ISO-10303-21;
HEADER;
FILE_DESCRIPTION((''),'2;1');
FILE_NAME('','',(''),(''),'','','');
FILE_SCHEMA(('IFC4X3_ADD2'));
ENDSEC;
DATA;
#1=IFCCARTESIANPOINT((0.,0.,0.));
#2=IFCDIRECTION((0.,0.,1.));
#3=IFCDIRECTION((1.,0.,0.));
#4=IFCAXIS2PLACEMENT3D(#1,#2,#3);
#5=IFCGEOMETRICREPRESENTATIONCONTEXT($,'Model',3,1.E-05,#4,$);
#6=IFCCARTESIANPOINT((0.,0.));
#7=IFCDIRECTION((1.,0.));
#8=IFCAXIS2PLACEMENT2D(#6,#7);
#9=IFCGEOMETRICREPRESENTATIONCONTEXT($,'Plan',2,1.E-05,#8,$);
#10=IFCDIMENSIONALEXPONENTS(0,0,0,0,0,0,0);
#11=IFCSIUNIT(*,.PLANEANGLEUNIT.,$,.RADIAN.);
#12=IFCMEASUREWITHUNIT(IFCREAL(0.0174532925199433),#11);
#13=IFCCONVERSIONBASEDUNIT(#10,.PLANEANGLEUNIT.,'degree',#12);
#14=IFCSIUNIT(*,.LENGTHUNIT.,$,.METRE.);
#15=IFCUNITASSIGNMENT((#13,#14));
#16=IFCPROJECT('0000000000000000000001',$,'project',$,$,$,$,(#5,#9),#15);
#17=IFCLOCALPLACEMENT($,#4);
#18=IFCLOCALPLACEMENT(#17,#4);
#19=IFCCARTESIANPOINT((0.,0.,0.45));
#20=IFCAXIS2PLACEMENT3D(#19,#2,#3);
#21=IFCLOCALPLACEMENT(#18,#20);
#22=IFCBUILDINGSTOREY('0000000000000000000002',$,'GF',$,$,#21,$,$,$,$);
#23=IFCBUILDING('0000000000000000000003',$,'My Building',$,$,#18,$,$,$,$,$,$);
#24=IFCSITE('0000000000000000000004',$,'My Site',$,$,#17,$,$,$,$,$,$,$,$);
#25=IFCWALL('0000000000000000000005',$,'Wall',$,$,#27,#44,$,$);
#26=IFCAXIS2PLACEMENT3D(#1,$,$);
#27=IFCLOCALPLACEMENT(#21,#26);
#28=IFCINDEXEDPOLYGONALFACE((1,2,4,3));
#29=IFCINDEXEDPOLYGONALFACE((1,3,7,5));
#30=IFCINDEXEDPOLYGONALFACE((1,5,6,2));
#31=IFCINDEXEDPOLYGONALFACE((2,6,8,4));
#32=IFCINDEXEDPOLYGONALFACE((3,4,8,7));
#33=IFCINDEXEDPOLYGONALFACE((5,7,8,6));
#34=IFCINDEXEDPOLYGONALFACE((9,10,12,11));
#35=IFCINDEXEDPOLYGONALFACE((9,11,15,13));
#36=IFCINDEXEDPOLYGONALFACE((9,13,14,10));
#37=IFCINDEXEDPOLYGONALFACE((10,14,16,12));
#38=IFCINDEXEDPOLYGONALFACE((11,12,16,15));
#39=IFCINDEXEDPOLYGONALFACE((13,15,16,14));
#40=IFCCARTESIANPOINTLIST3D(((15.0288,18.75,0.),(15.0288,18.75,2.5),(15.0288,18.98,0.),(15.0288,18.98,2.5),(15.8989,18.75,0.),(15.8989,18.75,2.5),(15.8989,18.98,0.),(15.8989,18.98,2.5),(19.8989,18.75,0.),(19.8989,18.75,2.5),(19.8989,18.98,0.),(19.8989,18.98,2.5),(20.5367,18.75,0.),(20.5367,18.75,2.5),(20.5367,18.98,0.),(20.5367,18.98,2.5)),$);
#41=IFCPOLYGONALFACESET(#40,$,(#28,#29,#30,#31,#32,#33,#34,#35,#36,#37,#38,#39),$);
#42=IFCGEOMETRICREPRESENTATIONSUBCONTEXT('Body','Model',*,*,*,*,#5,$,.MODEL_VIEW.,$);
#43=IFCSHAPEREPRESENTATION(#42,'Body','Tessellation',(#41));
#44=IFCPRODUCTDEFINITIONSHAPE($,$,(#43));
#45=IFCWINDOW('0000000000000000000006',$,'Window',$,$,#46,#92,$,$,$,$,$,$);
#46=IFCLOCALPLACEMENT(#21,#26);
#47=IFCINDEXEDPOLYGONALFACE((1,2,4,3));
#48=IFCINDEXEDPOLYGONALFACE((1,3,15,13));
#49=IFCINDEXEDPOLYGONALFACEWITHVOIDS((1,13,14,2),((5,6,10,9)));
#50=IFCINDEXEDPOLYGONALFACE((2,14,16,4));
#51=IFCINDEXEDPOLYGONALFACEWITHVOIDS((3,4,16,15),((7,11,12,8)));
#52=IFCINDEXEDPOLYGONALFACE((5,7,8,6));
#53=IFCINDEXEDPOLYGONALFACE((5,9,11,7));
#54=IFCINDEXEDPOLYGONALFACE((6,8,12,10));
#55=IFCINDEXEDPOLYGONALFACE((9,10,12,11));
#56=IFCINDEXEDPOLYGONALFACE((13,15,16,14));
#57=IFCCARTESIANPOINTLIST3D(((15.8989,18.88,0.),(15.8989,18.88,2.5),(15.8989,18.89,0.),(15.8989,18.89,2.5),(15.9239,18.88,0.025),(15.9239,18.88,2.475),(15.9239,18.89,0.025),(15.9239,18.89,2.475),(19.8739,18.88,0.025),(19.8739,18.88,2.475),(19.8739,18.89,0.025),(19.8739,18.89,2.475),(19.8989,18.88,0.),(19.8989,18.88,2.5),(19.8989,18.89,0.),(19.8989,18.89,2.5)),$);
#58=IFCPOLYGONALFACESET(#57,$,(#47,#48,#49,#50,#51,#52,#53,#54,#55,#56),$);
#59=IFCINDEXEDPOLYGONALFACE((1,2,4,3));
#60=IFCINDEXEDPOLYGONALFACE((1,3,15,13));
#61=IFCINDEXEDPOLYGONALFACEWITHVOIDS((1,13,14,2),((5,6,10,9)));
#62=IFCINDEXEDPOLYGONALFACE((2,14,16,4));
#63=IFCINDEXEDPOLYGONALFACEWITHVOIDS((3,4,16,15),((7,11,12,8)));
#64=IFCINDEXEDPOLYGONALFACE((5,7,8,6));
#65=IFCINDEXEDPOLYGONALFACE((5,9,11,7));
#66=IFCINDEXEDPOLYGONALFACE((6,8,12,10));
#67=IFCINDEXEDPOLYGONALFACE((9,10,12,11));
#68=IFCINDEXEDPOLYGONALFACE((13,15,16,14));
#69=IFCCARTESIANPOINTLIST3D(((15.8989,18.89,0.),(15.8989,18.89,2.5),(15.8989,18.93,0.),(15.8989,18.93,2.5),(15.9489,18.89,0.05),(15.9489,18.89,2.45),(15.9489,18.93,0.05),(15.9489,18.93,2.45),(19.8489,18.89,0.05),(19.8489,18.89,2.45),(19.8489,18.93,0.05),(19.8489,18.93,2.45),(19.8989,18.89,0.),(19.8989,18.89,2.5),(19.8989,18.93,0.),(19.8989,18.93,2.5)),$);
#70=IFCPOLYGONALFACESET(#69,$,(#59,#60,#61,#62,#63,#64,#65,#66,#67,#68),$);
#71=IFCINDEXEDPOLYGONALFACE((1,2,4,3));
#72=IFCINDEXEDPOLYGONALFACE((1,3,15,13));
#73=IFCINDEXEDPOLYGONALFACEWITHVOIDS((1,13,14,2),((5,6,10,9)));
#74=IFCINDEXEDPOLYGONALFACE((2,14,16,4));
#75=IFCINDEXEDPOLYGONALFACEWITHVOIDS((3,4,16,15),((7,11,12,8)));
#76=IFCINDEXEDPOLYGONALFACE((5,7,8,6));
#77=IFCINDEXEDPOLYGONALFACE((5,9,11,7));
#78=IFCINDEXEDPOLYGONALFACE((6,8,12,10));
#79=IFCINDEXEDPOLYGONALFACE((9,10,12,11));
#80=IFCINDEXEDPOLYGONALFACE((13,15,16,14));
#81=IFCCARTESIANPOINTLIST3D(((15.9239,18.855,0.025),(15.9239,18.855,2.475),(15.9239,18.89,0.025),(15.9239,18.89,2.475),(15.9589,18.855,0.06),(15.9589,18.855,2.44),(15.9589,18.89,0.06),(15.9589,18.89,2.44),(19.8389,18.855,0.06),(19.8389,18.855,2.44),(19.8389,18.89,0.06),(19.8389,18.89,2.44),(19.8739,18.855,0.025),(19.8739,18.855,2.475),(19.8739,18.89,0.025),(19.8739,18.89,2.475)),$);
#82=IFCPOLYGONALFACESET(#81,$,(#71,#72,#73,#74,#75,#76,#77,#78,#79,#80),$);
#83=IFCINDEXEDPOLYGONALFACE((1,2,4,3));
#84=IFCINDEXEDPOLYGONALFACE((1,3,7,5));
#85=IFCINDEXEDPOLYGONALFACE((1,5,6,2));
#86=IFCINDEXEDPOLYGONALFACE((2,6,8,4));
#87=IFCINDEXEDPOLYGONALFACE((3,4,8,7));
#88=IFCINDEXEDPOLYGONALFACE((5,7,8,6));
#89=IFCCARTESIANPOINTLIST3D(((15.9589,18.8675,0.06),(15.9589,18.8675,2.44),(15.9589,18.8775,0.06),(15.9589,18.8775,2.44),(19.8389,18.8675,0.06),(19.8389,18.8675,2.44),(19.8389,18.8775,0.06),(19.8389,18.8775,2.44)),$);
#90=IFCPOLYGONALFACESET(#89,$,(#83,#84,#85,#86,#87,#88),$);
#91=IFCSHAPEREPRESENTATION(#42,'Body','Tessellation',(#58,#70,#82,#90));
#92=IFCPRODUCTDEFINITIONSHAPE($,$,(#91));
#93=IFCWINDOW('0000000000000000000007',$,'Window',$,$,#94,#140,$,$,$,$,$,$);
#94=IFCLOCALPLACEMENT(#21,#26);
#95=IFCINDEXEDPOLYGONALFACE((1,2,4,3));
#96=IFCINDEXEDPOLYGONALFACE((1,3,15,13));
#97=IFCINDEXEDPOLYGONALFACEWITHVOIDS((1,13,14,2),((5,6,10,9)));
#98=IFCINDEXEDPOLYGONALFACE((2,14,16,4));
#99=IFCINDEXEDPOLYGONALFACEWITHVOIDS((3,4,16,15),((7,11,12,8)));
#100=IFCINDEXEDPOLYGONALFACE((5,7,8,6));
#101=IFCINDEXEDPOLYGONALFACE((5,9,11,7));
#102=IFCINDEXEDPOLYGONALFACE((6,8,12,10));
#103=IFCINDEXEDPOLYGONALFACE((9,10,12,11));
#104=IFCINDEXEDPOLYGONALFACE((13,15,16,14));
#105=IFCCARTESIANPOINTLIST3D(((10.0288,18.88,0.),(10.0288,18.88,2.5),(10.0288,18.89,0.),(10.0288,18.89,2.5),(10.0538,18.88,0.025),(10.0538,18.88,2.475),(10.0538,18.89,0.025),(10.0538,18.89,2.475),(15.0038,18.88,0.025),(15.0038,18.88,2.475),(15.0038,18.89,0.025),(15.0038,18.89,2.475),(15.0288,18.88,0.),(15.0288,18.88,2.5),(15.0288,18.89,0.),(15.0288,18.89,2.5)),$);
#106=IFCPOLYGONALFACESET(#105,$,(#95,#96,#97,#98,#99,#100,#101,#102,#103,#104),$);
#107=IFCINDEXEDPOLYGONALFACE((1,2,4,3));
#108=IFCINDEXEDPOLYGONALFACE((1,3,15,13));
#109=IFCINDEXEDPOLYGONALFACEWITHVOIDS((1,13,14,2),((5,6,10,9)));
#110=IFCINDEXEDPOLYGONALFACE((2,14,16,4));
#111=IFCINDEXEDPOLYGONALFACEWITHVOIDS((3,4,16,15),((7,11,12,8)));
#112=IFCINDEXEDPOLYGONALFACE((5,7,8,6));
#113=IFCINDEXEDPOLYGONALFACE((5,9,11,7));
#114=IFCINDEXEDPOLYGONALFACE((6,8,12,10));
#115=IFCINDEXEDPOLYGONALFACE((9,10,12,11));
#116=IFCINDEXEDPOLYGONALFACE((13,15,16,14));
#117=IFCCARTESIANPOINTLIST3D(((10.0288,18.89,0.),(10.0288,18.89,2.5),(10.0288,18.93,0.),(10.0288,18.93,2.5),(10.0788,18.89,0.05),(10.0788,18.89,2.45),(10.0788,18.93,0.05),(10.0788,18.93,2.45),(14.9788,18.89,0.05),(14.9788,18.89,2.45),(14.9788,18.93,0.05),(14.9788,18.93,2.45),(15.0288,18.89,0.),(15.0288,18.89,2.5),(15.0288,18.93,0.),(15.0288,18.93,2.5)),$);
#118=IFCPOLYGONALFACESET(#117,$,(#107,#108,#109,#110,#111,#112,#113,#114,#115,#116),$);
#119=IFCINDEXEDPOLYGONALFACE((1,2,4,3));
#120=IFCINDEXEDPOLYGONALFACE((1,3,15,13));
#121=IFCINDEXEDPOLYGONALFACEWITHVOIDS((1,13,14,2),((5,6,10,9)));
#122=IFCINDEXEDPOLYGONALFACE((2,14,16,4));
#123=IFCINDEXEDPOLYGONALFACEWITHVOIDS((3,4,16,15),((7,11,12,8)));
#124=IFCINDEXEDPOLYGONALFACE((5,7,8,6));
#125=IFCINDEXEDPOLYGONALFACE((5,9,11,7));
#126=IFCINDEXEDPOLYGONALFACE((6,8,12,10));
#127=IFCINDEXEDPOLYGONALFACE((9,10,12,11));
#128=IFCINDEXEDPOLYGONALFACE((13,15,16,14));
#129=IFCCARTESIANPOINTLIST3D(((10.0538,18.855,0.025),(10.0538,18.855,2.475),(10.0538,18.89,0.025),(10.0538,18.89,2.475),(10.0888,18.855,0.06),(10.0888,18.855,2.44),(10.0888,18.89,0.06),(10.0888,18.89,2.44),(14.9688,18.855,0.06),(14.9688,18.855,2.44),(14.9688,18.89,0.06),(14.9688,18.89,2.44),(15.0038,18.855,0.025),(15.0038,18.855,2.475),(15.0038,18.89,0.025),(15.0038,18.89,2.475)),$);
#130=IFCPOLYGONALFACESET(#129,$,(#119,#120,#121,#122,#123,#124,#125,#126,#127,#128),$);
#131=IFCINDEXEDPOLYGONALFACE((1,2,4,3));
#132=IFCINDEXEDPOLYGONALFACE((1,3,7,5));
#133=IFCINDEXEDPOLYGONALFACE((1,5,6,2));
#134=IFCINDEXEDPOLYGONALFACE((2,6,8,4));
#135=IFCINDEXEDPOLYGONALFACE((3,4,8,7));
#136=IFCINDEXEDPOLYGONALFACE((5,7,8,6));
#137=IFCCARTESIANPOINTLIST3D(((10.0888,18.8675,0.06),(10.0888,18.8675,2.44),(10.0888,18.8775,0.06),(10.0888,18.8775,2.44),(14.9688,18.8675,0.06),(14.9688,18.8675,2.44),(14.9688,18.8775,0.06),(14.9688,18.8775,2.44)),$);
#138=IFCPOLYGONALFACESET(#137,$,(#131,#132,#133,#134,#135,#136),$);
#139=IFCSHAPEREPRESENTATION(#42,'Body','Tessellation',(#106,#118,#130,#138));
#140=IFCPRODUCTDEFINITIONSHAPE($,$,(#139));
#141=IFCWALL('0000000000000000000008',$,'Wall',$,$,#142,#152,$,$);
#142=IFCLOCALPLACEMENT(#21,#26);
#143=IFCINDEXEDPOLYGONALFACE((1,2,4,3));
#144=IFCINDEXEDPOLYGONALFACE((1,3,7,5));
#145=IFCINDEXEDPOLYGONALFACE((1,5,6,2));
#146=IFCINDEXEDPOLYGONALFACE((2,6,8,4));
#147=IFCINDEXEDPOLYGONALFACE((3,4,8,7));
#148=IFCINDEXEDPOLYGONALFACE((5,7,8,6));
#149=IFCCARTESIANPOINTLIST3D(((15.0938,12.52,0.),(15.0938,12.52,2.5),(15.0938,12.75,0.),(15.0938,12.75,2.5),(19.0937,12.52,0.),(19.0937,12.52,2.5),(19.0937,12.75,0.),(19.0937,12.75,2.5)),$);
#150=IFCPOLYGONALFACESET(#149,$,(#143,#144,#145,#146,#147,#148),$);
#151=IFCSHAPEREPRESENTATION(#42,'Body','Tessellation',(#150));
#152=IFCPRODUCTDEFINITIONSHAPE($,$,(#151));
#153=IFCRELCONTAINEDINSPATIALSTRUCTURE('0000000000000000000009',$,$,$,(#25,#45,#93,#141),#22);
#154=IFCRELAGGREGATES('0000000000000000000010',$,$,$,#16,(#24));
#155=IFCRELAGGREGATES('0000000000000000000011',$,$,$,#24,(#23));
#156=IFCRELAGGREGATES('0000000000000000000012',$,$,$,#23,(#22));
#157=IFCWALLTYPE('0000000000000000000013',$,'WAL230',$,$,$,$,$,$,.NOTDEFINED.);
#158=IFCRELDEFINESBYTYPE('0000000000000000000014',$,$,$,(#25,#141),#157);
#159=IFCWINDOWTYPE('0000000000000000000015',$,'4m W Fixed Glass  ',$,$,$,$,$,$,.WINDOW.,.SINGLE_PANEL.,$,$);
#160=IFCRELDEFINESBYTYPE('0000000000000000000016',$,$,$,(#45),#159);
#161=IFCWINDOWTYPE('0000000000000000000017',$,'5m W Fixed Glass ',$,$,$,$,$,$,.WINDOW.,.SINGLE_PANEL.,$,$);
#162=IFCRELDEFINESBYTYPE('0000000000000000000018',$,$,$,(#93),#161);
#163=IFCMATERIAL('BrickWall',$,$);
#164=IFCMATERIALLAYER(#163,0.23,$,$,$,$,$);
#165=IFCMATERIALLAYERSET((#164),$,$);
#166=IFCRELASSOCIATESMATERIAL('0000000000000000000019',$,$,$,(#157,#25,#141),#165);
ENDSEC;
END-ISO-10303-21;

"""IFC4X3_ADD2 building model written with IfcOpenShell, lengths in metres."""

from ifc_helpers import new_model, entity, si_unit, converted_unit, frame, origin_with_axes, origin_2d_with_axis, place, context, subcontext, project, spatial, line, indexed_curve, outline, extrude, shape, source, transform, mapped, material, layer, layer_set, layer_usage, type_object, type_shapes, element, fill, save


model = new_model("IFC4X3_ADD2")

# Units and contexts
model_context = context("Model", 3, precision=1e-05, world=origin_with_axes())
plan_context = context("Plan", 2, precision=1e-05, world=origin_2d_with_axis())
body_context_1 = subcontext(model_context, "Body", "Model", "MODEL_VIEW")
body_context_2 = subcontext(plan_context, "Body", "Plan", "PLAN_VIEW")
ifc_project = project(units=[converted_unit("PLANEANGLEUNIT", "degree", entity("IfcReal", 0.0174532925199433), si_unit("PLANEANGLEUNIT", "RADIAN"), dimensions=[0, 0, 0, 0, 0, 0, 0]), si_unit("LENGTHUNIT", "METRE")], contexts=[model_context, plan_context])

# Site, building, storey
site_placement = place(None, origin_with_axes())
site = spatial("IfcSite", under=ifc_project, at=site_placement, Name="My Site")
building_placement = place(site_placement, origin_with_axes())
building = spatial("IfcBuilding", under=site, at=building_placement, Name="My Building")
storey_placement = place(building_placement, frame((0.0, 0.0, 0.45), z_axis=(0.0, 0.0, 1.0), x_axis=(1.0, 0.0, 0.0)))
storey = spatial("IfcBuildingStorey", under=building, at=storey_placement, Name="GF")

# Wall, openings, windows
ifc_material_1 = material(Name="BrickWall")
ifc_layer_1 = layer(ifc_material_1, 0.23)
ifc_layer_set_1 = layer_set([ifc_layer_1])
ifc_layer_usage_1 = layer_usage(ifc_layer_set_1, "AXIS2", "POSITIVE", 0.0)
wall_type_1 = type_object("IfcWallType", Name="WAL230", PredefinedType="NOTDEFINED", material=ifc_layer_set_1)
wall_1_placement = place(storey_placement, frame((20.5367, 18.98, 0.0), z_axis=(0.0, 0.0, 1.0), x_axis=(-1.0, 0.0, 0.0)))
wall_1 = element("IfcWall", 1, at=wall_1_placement, inside=storey, type_object=wall_type_1, material=ifc_layer_usage_1, Name="Wall", context=body_context_1, shape_type="SweptSolid", body=[
    extrude(outline(indexed_curve([(0.0, 0.0), (0.0, 0.23), (10.5079, 0.23), (10.5079, 0.0), (0.0, 0.0)], self_intersect=False)), origin_with_axes(), (0.0, 0.0, 1.0), 2.5),
])
shared_shape_1 = source(origin_with_axes(), body_context_1, "Body", "SweptSolid", [
    extrude(outline(indexed_curve([(0.0, 0.0), (5.0, 0.0), (5.0, 2.5), (0.0, 2.5)], segments=[line(1, 2, 3, 4, 1)])), frame((0.0, -0.6, 0.0), z_axis=(0.0, -1.0, 0.0), x_axis=(1.0, 0.0, 0.0)), (0.0, 0.0, -1.0), 1.2),
])
opening_1_placement = place(wall_1_placement, frame((5.5079, 0.0, 0.0), z_axis=(0.0, 0.0, 1.0), x_axis=(1.0, 0.0, 0.0)))
opening_1 = element("IfcOpeningElement", 2, at=opening_1_placement, cuts=wall_1, PredefinedType="OPENING", context=body_context_1, shape_type="MappedRepresentation", body=[
    mapped(shared_shape_1, transform((0.0, 0.0, 0.0), x_axis=(1.0, 0.0, 0.0), y_axis=(0.0, 1.0, 0.0), z_axis=(0.0, 0.0, 1.0), scale=1.0)),
])
shared_shape_2 = source(origin_with_axes(), body_context_1, "Body", "SweptSolid", [
    extrude(outline(indexed_curve([(0.0, 0.0), (4.0, 0.0), (4.0, 2.5), (0.0, 2.5)], segments=[line(1, 2, 3, 4, 1)])), frame((0.0, -0.6, 0.0), z_axis=(0.0, -1.0, 0.0), x_axis=(1.0, 0.0, 0.0)), (0.0, 0.0, -1.0), 1.2),
])
opening_2_placement = place(wall_1_placement, frame((0.6379, 0.0, 0.0), z_axis=(0.0, 0.0, 1.0), x_axis=(1.0, 0.0, 0.0)))
opening_2 = element("IfcOpeningElement", 3, at=opening_2_placement, cuts=wall_1, PredefinedType="OPENING", context=body_context_1, shape_type="MappedRepresentation", body=[
    mapped(shared_shape_2, transform((0.0, 0.0, 0.0), x_axis=(1.0, 0.0, 0.0), y_axis=(0.0, 1.0, 0.0), z_axis=(0.0, 0.0, 1.0), scale=1.0)),
])
window_type_1 = type_object("IfcWindowType", Name="4m W Fixed Glass  ", PartitioningType="SINGLE_PANEL", PredefinedType="WINDOW")
shared_shape_3 = source(origin_with_axes(), body_context_1, "Body", "SweptSolid", [
    extrude(outline(indexed_curve([(0.0, 0.0), (4.0, 0.0), (4.0, 2.5), (0.0, 2.5)], segments=[line(1, 2, 3, 4, 1)]), holes=[indexed_curve([(0.025, 0.025), (3.975, 0.025), (3.975, 2.475), (0.025, 2.475)], segments=[line(1, 2, 3, 4, 1)])]), frame((0.0, 0.09, 0.0), z_axis=(0.0, -1.0, 0.0), x_axis=(1.0, 0.0, 0.0)), (0.0, 0.0, -1.0), 0.01),
    extrude(outline(indexed_curve([(0.0, 0.0), (4.0, 0.0), (4.0, 2.5), (0.0, 2.5)], segments=[line(1, 2, 3, 4, 1)]), holes=[indexed_curve([(0.05, 0.05), (3.95, 0.05), (3.95, 2.45), (0.05, 2.45)], segments=[line(1, 2, 3, 4, 1)])]), frame((0.0, 0.05, 0.0), z_axis=(0.0, -1.0, 0.0), x_axis=(1.0, 0.0, 0.0)), (0.0, 0.0, -1.0), 0.04),
    extrude(outline(indexed_curve([(0.0, 0.0), (3.95, 0.0), (3.95, 2.45), (0.0, 2.45)], segments=[line(1, 2, 3, 4, 1)]), holes=[indexed_curve([(0.035, 0.035), (3.915, 0.035), (3.915, 2.415), (0.035, 2.415)], segments=[line(1, 2, 3, 4, 1)])]), frame((0.025, 0.09, 0.025), z_axis=(0.0, -1.0, 0.0), x_axis=(1.0, 0.0, 0.0)), (0.0, 0.0, -1.0), 0.035),
    extrude(outline(indexed_curve([(0.035, 0.035), (3.915, 0.035), (3.915, 2.415), (0.035, 2.415)], segments=[line(1, 2, 3, 4, 1)])), frame((0.025, 0.1025, 0.025), z_axis=(0.0, -1.0, 0.0), x_axis=(1.0, 0.0, 0.0)), (0.0, 0.0, -1.0), 0.01),
])
shared_shape_4 = source(origin_with_axes(), body_context_2, "Body", "Curve2D", [
    entity("IfcIndexedPolyCurve", entity("IfcCartesianPointList2D", [[0.05, 0.05], [3.95, 0.05]])),
    entity("IfcIndexedPolyCurve", entity("IfcCartesianPointList2D", [[0.0, 0.1], [0.025, 0.1], [0.025, 0.09], [0.05, 0.09], [0.05, 0.05], [0.0, 0.05]]), [entity("IfcLineIndex", [1, 2, 3, 4, 5, 6, 1])]),
    entity("IfcIndexedPolyCurve", entity("IfcCartesianPointList2D", [[4.0, 0.1], [3.975, 0.1], [3.975, 0.09], [3.95, 0.09], [3.95, 0.05], [4.0, 0.05]]), [entity("IfcLineIndex", [1, 2, 3, 4, 5, 6, 1])]),
    entity("IfcIndexedPolyCurve", entity("IfcCartesianPointList2D", [[0.025, 0.09], [0.06, 0.09], [0.06, 0.125], [0.025, 0.125]]), [entity("IfcLineIndex", [1, 2, 3, 4, 1])]),
    entity("IfcIndexedPolyCurve", entity("IfcCartesianPointList2D", [[3.975, 0.09], [3.94, 0.09], [3.94, 0.125], [3.975, 0.125]]), [entity("IfcLineIndex", [1, 2, 3, 4, 1])]),
    entity("IfcIndexedPolyCurve", entity("IfcCartesianPointList2D", [[0.06, 0.09], [3.94, 0.09]])),
    entity("IfcIndexedPolyCurve", entity("IfcCartesianPointList2D", [[0.06, 0.125], [3.94, 0.125]])),
    entity("IfcIndexedPolyCurve", entity("IfcCartesianPointList2D", [[0.06, 0.1075], [3.94, 0.1075]])),
])
type_shapes(window_type_1, [shared_shape_3, shared_shape_4])
window_1_placement = place(opening_2_placement, frame((0.0, 0.0, 0.0), z_axis=(0.0, 0.0, 1.0), x_axis=(1.0, 0.0, 0.0)))
window_1 = element("IfcWindow", 4, at=window_1_placement, inside=storey, type_object=window_type_1, Name="Window", shapes=[
    shape(body_context_1, "Body", "MappedRepresentation", [mapped(shared_shape_3, transform((0.0, 0.0, 0.0), x_axis=(1.0, 0.0, 0.0), y_axis=(0.0, 1.0, 0.0), z_axis=(0.0, 0.0, 1.0), scale=1.0))]),
    shape(body_context_2, "Body", "MappedRepresentation", [mapped(shared_shape_4, transform((0.0, 0.0, 0.0), x_axis=(1.0, 0.0, 0.0), y_axis=(0.0, 1.0, 0.0), z_axis=(0.0, 0.0, 1.0), scale=1.0))]),
])
fill(opening_2, window_1)
window_type_2 = type_object("IfcWindowType", Name="5m W Fixed Glass ", PartitioningType="SINGLE_PANEL", PredefinedType="WINDOW")
shared_shape_5 = source(origin_with_axes(), body_context_1, "Body", "SweptSolid", [
    extrude(outline(indexed_curve([(0.0, 0.0), (5.0, 0.0), (5.0, 2.5), (0.0, 2.5)], segments=[line(1, 2, 3, 4, 1)]), holes=[indexed_curve([(0.025, 0.025), (4.975, 0.025), (4.975, 2.475), (0.025, 2.475)], segments=[line(1, 2, 3, 4, 1)])]), frame((0.0, 0.09, 0.0), z_axis=(0.0, -1.0, 0.0), x_axis=(1.0, 0.0, 0.0)), (0.0, 0.0, -1.0), 0.01),
    extrude(outline(indexed_curve([(0.0, 0.0), (5.0, 0.0), (5.0, 2.5), (0.0, 2.5)], segments=[line(1, 2, 3, 4, 1)]), holes=[indexed_curve([(0.05, 0.05), (4.95, 0.05), (4.95, 2.45), (0.05, 2.45)], segments=[line(1, 2, 3, 4, 1)])]), frame((0.0, 0.05, 0.0), z_axis=(0.0, -1.0, 0.0), x_axis=(1.0, 0.0, 0.0)), (0.0, 0.0, -1.0), 0.04),
    extrude(outline(indexed_curve([(0.0, 0.0), (4.95, 0.0), (4.95, 2.45), (0.0, 2.45)], segments=[line(1, 2, 3, 4, 1)]), holes=[indexed_curve([(0.035, 0.035), (4.915, 0.035), (4.915, 2.415), (0.035, 2.415)], segments=[line(1, 2, 3, 4, 1)])]), frame((0.025, 0.09, 0.025), z_axis=(0.0, -1.0, 0.0), x_axis=(1.0, 0.0, 0.0)), (0.0, 0.0, -1.0), 0.035),
    extrude(outline(indexed_curve([(0.035, 0.035), (4.915, 0.035), (4.915, 2.415), (0.035, 2.415)], segments=[line(1, 2, 3, 4, 1)])), frame((0.025, 0.1025, 0.025), z_axis=(0.0, -1.0, 0.0), x_axis=(1.0, 0.0, 0.0)), (0.0, 0.0, -1.0), 0.01),
])
shared_shape_6 = source(origin_with_axes(), body_context_2, "Body", "Curve2D", [
    entity("IfcIndexedPolyCurve", entity("IfcCartesianPointList2D", [[0.05, 0.05], [4.95, 0.05]])),
    entity("IfcIndexedPolyCurve", entity("IfcCartesianPointList2D", [[0.0, 0.1], [0.025, 0.1], [0.025, 0.09], [0.05, 0.09], [0.05, 0.05], [0.0, 0.05]]), [entity("IfcLineIndex", [1, 2, 3, 4, 5, 6, 1])]),
    entity("IfcIndexedPolyCurve", entity("IfcCartesianPointList2D", [[5.0, 0.1], [4.975, 0.1], [4.975, 0.09], [4.95, 0.09], [4.95, 0.05], [5.0, 0.05]]), [entity("IfcLineIndex", [1, 2, 3, 4, 5, 6, 1])]),
    entity("IfcIndexedPolyCurve", entity("IfcCartesianPointList2D", [[0.025, 0.09], [0.06, 0.09], [0.06, 0.125], [0.025, 0.125]]), [entity("IfcLineIndex", [1, 2, 3, 4, 1])]),
    entity("IfcIndexedPolyCurve", entity("IfcCartesianPointList2D", [[4.975, 0.09], [4.94, 0.09], [4.94, 0.125], [4.975, 0.125]]), [entity("IfcLineIndex", [1, 2, 3, 4, 1])]),
    entity("IfcIndexedPolyCurve", entity("IfcCartesianPointList2D", [[0.06, 0.09], [4.94, 0.09]])),
    entity("IfcIndexedPolyCurve", entity("IfcCartesianPointList2D", [[0.06, 0.125], [4.94, 0.125]])),
    entity("IfcIndexedPolyCurve", entity("IfcCartesianPointList2D", [[0.06, 0.1075], [4.94, 0.1075]])),
])
type_shapes(window_type_2, [shared_shape_5, shared_shape_6])
window_2_placement = place(opening_1_placement, frame((0.0, 0.0, 0.0), z_axis=(0.0, 0.0, 1.0), x_axis=(1.0, 0.0, 0.0)))
window_2 = element("IfcWindow", 5, at=window_2_placement, inside=storey, type_object=window_type_2, Name="Window", shapes=[
    shape(body_context_1, "Body", "MappedRepresentation", [mapped(shared_shape_5, transform((0.0, 0.0, 0.0), x_axis=(1.0, 0.0, 0.0), y_axis=(0.0, 1.0, 0.0), z_axis=(0.0, 0.0, 1.0), scale=1.0))]),
    shape(body_context_2, "Body", "MappedRepresentation", [mapped(shared_shape_6, transform((0.0, 0.0, 0.0), x_axis=(1.0, 0.0, 0.0), y_axis=(0.0, 1.0, 0.0), z_axis=(0.0, 0.0, 1.0), scale=1.0))]),
])
fill(opening_1, window_2)

# Wall
ifc_layer_usage_2 = layer_usage(ifc_layer_set_1, "AXIS2", "POSITIVE", 0.0)
wall_2_placement = place(storey_placement, frame((19.0937, 12.75, 0.0), z_axis=(0.0, 0.0, 1.0), x_axis=(-1.0, 0.0, 0.0)))
element("IfcWall", 6, at=wall_2_placement, inside=storey, type_object=wall_type_1, material=ifc_layer_usage_2, Name="Wall", context=body_context_1, shape_type="SweptSolid", body=[
    extrude(outline(indexed_curve([(0.0, 0.0), (0.0, 0.23), (3.9999, 0.23), (3.9999, 0.0), (0.0, 0.0)], self_intersect=False)), origin_with_axes(), (0.0, 0.0, 1.0), 2.5),
])

save(model, "model.ifc")
